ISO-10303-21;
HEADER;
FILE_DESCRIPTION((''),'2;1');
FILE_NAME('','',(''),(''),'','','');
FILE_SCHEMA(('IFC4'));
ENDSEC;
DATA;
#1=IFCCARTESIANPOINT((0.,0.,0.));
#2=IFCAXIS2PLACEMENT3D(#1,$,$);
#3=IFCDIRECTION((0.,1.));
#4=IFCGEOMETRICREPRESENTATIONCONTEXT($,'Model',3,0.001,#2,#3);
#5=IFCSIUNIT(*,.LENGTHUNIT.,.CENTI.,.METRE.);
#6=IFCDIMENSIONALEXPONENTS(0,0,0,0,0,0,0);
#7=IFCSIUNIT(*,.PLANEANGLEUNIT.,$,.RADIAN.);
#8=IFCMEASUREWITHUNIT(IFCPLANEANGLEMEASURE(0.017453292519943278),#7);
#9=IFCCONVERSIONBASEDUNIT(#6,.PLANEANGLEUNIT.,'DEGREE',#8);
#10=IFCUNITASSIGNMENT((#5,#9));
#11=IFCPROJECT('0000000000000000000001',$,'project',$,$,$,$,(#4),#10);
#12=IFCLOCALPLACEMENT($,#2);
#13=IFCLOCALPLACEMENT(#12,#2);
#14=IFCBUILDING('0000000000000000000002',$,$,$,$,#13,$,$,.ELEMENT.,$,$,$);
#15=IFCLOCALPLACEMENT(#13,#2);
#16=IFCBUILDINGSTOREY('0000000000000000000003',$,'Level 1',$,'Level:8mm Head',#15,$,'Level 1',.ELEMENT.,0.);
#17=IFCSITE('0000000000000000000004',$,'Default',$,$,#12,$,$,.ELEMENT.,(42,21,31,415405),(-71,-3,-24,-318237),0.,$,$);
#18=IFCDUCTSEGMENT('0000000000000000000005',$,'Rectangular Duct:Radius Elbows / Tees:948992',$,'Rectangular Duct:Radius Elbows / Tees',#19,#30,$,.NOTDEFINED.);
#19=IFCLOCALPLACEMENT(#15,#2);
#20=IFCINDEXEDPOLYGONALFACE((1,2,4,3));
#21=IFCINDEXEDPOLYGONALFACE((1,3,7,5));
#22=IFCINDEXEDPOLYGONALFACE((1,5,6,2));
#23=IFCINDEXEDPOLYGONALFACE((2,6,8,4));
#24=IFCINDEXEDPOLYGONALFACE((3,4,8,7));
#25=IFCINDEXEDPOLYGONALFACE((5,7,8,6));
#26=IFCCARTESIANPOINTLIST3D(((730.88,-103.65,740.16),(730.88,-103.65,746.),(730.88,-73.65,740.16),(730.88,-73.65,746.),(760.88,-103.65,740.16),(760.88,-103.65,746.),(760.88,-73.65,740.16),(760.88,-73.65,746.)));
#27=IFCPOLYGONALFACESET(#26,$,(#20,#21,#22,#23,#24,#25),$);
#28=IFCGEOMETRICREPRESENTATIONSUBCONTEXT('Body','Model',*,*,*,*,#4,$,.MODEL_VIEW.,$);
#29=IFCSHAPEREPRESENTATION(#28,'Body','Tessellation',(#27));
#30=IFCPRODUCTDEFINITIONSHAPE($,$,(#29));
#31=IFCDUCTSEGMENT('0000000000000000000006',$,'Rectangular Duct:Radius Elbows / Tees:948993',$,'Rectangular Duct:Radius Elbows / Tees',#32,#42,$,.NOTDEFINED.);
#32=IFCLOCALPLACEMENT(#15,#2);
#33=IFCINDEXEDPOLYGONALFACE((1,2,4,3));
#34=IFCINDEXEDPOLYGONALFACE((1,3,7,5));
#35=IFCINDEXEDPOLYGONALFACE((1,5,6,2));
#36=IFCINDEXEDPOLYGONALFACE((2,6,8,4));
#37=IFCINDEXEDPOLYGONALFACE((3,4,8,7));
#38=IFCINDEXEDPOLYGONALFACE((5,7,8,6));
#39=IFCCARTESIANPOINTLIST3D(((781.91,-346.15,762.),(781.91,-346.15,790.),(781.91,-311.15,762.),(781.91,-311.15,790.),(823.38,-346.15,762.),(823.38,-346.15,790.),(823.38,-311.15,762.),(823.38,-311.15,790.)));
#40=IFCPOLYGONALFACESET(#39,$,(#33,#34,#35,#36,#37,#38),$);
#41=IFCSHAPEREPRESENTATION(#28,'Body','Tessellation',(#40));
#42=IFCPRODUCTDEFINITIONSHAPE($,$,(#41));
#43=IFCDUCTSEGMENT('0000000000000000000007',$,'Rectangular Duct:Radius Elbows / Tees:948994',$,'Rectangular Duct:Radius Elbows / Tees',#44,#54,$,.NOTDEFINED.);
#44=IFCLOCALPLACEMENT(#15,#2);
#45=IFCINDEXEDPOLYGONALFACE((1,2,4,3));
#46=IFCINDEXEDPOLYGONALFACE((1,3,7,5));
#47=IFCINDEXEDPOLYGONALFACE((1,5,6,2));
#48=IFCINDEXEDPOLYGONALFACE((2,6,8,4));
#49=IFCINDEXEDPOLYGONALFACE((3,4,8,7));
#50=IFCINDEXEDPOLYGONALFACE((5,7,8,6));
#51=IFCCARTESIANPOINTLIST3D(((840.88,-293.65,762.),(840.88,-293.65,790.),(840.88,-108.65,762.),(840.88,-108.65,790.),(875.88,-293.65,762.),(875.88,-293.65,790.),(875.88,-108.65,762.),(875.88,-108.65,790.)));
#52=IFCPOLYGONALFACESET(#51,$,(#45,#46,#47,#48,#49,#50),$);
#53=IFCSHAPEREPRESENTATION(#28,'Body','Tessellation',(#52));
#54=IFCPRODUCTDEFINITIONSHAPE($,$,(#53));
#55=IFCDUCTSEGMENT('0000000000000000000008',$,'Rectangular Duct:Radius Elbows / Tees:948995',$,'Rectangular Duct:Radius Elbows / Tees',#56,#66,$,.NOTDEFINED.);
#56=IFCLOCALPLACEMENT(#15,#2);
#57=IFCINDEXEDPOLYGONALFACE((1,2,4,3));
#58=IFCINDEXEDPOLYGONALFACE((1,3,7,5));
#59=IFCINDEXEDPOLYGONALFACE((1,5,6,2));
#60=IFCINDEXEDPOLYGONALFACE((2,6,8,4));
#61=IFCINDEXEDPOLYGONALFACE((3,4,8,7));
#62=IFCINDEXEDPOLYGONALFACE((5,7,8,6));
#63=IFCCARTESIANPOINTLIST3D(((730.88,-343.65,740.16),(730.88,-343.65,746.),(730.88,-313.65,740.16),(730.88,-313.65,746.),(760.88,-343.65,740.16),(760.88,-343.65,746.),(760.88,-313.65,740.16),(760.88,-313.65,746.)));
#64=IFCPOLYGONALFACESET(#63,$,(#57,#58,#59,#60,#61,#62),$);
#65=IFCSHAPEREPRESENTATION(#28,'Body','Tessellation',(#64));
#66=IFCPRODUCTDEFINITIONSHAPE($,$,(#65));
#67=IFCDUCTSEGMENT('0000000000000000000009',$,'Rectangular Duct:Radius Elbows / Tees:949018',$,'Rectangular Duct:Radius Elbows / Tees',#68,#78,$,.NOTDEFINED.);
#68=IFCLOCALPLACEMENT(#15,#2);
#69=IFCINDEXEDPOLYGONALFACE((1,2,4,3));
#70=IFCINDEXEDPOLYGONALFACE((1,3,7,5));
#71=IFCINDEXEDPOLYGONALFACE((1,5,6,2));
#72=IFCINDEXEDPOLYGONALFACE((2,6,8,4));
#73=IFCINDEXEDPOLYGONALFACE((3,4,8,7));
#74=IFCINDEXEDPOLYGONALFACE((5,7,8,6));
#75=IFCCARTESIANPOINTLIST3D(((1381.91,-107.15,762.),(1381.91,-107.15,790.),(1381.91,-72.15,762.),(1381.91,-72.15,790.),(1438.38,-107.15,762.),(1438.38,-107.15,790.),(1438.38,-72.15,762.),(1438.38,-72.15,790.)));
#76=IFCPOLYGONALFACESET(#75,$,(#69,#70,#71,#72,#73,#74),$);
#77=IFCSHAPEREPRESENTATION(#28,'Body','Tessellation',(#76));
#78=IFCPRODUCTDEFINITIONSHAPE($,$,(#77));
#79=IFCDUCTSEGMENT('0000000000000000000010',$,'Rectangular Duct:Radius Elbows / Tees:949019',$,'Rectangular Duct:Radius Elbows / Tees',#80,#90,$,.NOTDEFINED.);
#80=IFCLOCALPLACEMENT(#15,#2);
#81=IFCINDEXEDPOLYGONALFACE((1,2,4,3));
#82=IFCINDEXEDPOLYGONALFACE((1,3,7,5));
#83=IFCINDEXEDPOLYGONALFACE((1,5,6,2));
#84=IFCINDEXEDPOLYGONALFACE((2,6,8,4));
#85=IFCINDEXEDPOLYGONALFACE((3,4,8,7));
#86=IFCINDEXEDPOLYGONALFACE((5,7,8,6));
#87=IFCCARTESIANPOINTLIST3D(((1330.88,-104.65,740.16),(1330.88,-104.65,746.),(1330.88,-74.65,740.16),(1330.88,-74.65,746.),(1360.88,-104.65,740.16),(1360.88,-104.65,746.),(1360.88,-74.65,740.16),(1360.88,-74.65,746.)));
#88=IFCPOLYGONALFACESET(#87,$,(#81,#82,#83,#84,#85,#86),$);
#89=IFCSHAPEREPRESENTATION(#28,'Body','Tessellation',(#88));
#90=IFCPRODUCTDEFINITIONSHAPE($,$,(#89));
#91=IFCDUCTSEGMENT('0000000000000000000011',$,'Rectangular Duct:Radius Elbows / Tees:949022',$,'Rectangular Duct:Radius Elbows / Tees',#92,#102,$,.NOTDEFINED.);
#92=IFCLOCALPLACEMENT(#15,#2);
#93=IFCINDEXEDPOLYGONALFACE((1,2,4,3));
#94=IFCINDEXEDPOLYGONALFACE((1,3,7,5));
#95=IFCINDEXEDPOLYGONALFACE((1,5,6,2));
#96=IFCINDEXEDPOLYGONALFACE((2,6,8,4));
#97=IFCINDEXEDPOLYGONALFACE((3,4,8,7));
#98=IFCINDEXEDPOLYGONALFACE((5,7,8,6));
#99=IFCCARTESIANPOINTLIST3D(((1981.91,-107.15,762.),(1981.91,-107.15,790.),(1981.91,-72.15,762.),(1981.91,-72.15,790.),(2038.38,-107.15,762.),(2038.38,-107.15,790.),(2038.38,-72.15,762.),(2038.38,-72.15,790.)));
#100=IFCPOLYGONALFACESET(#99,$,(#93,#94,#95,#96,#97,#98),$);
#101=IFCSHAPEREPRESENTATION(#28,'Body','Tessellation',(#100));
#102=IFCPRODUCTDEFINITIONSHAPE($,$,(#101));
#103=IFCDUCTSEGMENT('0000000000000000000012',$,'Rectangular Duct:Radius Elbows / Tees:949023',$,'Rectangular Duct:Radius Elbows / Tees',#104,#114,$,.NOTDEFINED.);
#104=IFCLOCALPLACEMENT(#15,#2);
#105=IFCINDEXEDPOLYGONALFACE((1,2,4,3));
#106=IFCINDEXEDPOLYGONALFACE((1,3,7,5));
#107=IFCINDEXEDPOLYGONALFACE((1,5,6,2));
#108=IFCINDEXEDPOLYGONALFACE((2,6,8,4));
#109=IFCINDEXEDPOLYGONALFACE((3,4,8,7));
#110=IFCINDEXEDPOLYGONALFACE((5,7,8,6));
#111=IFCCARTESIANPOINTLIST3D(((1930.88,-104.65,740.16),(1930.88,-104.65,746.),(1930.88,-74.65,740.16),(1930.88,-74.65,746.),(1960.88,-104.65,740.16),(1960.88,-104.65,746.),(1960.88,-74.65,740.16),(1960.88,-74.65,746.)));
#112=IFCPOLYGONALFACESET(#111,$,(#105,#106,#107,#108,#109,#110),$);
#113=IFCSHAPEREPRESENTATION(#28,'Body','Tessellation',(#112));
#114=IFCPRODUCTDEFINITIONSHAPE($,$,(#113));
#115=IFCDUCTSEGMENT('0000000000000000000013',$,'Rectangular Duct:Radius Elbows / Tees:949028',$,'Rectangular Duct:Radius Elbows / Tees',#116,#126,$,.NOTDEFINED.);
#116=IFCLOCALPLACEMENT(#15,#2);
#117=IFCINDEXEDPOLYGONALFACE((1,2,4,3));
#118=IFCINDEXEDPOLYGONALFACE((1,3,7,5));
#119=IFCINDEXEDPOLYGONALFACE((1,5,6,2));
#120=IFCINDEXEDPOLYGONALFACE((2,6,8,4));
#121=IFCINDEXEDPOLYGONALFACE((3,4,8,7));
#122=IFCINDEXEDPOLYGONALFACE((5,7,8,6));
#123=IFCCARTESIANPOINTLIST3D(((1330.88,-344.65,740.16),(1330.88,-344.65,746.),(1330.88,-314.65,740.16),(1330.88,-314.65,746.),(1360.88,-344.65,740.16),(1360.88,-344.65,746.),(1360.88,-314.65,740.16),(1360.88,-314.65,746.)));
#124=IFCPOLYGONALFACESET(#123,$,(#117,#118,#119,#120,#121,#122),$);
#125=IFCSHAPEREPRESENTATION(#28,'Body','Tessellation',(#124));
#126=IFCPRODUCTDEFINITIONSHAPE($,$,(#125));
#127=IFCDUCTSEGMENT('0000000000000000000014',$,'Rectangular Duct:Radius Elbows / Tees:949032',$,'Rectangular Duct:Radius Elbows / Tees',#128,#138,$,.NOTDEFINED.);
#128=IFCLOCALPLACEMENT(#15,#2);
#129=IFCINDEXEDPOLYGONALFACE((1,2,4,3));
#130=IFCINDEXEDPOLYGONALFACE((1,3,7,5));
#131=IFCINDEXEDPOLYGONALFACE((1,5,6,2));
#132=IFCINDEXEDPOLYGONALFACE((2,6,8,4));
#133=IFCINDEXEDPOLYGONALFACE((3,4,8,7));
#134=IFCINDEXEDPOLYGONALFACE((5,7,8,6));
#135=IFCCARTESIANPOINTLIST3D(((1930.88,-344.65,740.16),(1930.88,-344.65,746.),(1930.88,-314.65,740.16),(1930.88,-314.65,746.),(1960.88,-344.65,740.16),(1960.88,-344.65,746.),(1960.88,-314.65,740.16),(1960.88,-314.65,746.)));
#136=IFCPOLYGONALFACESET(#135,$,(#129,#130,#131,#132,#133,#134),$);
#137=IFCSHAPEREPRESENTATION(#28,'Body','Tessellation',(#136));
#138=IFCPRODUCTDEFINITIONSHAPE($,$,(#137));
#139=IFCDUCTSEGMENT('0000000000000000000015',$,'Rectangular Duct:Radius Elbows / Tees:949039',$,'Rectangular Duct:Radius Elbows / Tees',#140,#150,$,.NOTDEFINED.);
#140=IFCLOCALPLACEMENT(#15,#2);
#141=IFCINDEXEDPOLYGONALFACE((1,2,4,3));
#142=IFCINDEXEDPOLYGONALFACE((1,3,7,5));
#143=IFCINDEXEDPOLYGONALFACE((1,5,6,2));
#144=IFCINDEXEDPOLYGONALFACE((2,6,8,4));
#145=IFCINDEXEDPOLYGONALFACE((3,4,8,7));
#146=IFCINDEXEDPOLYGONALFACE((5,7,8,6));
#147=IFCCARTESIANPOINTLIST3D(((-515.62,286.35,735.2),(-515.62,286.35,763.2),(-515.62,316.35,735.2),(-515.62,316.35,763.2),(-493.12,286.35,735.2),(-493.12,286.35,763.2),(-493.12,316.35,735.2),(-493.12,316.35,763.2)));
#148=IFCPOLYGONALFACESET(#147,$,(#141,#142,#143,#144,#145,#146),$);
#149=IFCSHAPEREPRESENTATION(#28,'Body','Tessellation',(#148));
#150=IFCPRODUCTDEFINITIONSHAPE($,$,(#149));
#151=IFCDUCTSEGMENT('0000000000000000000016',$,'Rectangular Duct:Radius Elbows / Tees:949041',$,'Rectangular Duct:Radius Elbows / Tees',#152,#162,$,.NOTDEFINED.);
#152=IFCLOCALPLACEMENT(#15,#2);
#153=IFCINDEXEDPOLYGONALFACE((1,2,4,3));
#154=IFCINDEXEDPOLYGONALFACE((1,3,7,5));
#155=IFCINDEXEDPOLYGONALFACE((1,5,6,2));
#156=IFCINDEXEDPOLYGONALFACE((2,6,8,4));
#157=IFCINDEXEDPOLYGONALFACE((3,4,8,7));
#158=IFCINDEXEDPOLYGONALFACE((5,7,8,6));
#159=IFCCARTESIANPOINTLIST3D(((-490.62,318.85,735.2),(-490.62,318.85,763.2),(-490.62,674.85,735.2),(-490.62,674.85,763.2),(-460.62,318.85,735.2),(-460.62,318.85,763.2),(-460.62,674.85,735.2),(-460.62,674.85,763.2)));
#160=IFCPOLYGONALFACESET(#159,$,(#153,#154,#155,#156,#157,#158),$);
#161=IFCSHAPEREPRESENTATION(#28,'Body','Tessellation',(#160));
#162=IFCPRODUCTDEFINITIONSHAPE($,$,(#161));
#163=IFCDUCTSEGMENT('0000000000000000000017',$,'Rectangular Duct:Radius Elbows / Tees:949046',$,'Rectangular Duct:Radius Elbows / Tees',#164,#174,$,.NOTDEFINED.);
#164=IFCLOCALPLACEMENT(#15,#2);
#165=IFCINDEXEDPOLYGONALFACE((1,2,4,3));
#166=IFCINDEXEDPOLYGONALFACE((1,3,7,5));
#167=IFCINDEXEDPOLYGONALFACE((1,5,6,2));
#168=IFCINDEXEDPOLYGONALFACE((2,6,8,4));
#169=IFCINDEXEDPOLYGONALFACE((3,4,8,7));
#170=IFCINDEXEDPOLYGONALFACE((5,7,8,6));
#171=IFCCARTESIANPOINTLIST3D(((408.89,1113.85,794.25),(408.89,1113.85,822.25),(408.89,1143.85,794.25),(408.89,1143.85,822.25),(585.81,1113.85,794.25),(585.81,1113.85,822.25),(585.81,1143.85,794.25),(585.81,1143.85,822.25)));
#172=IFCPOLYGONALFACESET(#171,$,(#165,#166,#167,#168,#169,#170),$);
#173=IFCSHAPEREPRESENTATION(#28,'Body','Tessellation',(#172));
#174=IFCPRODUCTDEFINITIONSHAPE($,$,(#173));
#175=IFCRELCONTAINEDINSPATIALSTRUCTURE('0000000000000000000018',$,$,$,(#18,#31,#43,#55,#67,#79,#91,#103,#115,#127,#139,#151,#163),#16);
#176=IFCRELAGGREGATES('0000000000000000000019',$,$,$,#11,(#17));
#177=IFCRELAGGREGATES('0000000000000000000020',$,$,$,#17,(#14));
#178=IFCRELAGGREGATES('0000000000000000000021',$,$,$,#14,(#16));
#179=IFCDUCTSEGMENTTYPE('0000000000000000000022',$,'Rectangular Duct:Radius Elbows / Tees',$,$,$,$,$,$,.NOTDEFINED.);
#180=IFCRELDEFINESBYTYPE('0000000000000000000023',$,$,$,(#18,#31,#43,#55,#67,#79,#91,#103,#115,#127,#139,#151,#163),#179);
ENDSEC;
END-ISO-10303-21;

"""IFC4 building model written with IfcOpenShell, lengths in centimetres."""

from ifc_helpers import new_model, entity, si_unit, converted_unit, direction, frame, origin, place, context, subcontext, project, spatial, indexed_curve, outline, extrude, type_object, element, save


model = new_model("IFC4")

# Units and contexts
model_context = context("Model", 3, precision=0.001, world=origin(), true_north=direction((0.0, 1.0)))
body_context = subcontext(model_context, "Body", "Model", "MODEL_VIEW")
ifc_project = project(units=[si_unit("LENGTHUNIT", "METRE", prefix="CENTI"), converted_unit("PLANEANGLEUNIT", "DEGREE", entity("IfcPlaneAngleMeasure", 0.017453292519943278), si_unit("PLANEANGLEUNIT", "RADIAN"), dimensions=[0, 0, 0, 0, 0, 0, 0])], contexts=[model_context])

# Site, building, storey
site_placement = place(None, origin())
site = spatial("IfcSite", under=ifc_project, at=site_placement, Name="Default", CompositionType="ELEMENT", RefLatitude=(42, 21, 31, 415405), RefLongitude=(-71, -3, -24, -318237), RefElevation=0.0)
building_placement = place(site_placement, origin())
building = spatial("IfcBuilding", under=site, at=building_placement, CompositionType="ELEMENT")
storey_placement = place(building_placement, origin())
storey = spatial("IfcBuildingStorey", under=building, at=storey_placement, Name="Level 1", ObjectType="Level:8mm Head", LongName="Level 1", CompositionType="ELEMENT", Elevation=0.0)

# Duct segments
duct_segment_type = type_object("IfcDuctSegmentType", Name="Rectangular Duct:Radius Elbows / Tees", PredefinedType="NOTDEFINED")
duct_segment_1_placement = place(storey_placement, origin())
element("IfcDuctSegment", 1, at=duct_segment_1_placement, inside=storey, type_object=duct_segment_type, Name="Rectangular Duct:Radius Elbows / Tees:948992", ObjectType="Rectangular Duct:Radius Elbows / Tees", PredefinedType="NOTDEFINED", context=body_context, shape_type="SweptSolid", body=[
    extrude(outline(indexed_curve([(-15.0, -15.0), (15.0, -15.0), (15.0, 15.0), (-15.0, 15.0), (-15.0, -15.0)], self_intersect=False)), frame((745.88, -88.65, 740.16)), (0.0, 0.0, 1.0), 5.84),
])
duct_segment_2_placement = place(storey_placement, origin())
element("IfcDuctSegment", 2, at=duct_segment_2_placement, inside=storey, type_object=duct_segment_type, Name="Rectangular Duct:Radius Elbows / Tees:948993", ObjectType="Rectangular Duct:Radius Elbows / Tees", PredefinedType="NOTDEFINED", context=body_context, shape_type="SweptSolid", body=[
    extrude(outline(indexed_curve([(-20.73, -17.5), (20.73, -17.5), (20.73, 17.5), (-20.73, 17.5), (-20.73, -17.5)], self_intersect=False)), frame((802.64, -328.65, 762.0)), (0.0, 0.0, 1.0), 28.0),
])
duct_segment_3_placement = place(storey_placement, origin())
element("IfcDuctSegment", 3, at=duct_segment_3_placement, inside=storey, type_object=duct_segment_type, Name="Rectangular Duct:Radius Elbows / Tees:948994", ObjectType="Rectangular Duct:Radius Elbows / Tees", PredefinedType="NOTDEFINED", context=body_context, shape_type="SweptSolid", body=[
    extrude(outline(indexed_curve([(-92.5, -17.5), (92.5, -17.5), (92.5, 17.5), (-92.5, 17.5), (-92.5, -17.5)], self_intersect=False)), frame((858.38, -201.15, 762.0), z_axis=(0.0, 0.0, 1.0), x_axis=(0.0, -1.0, 0.0)), (0.0, 0.0, 1.0), 28.0),
])
duct_segment_4_placement = place(storey_placement, origin())
element("IfcDuctSegment", 4, at=duct_segment_4_placement, inside=storey, type_object=duct_segment_type, Name="Rectangular Duct:Radius Elbows / Tees:948995", ObjectType="Rectangular Duct:Radius Elbows / Tees", PredefinedType="NOTDEFINED", context=body_context, shape_type="SweptSolid", body=[
    extrude(outline(indexed_curve([(-15.0, -15.0), (15.0, -15.0), (15.0, 15.0), (-15.0, 15.0), (-15.0, -15.0)], self_intersect=False)), frame((745.88, -328.65, 740.16)), (0.0, 0.0, 1.0), 5.84),
])
duct_segment_5_placement = place(storey_placement, origin())
element("IfcDuctSegment", 5, at=duct_segment_5_placement, inside=storey, type_object=duct_segment_type, Name="Rectangular Duct:Radius Elbows / Tees:949018", ObjectType="Rectangular Duct:Radius Elbows / Tees", PredefinedType="NOTDEFINED", context=body_context, shape_type="SweptSolid", body=[
    extrude(outline(indexed_curve([(-28.23, -17.5), (28.23, -17.5), (28.23, 17.5), (-28.23, 17.5), (-28.23, -17.5)], self_intersect=False)), frame((1410.14, -89.65, 762.0)), (0.0, 0.0, 1.0), 28.0),
])
duct_segment_6_placement = place(storey_placement, origin())
element("IfcDuctSegment", 6, at=duct_segment_6_placement, inside=storey, type_object=duct_segment_type, Name="Rectangular Duct:Radius Elbows / Tees:949019", ObjectType="Rectangular Duct:Radius Elbows / Tees", PredefinedType="NOTDEFINED", context=body_context, shape_type="SweptSolid", body=[
    extrude(outline(indexed_curve([(-15.0, -15.0), (15.0, -15.0), (15.0, 15.0), (-15.0, 15.0), (-15.0, -15.0)], self_intersect=False)), frame((1345.88, -89.65, 740.16)), (0.0, 0.0, 1.0), 5.84),
])
duct_segment_7_placement = place(storey_placement, origin())
element("IfcDuctSegment", 7, at=duct_segment_7_placement, inside=storey, type_object=duct_segment_type, Name="Rectangular Duct:Radius Elbows / Tees:949022", ObjectType="Rectangular Duct:Radius Elbows / Tees", PredefinedType="NOTDEFINED", context=body_context, shape_type="SweptSolid", body=[
    extrude(outline(indexed_curve([(-28.23, -17.5), (28.23, -17.5), (28.23, 17.5), (-28.23, 17.5), (-28.23, -17.5)], self_intersect=False)), frame((2010.14, -89.65, 762.0)), (0.0, 0.0, 1.0), 28.0),
])
duct_segment_8_placement = place(storey_placement, origin())
element("IfcDuctSegment", 8, at=duct_segment_8_placement, inside=storey, type_object=duct_segment_type, Name="Rectangular Duct:Radius Elbows / Tees:949023", ObjectType="Rectangular Duct:Radius Elbows / Tees", PredefinedType="NOTDEFINED", context=body_context, shape_type="SweptSolid", body=[
    extrude(outline(indexed_curve([(-15.0, -15.0), (15.0, -15.0), (15.0, 15.0), (-15.0, 15.0), (-15.0, -15.0)], self_intersect=False)), frame((1945.88, -89.65, 740.16)), (0.0, 0.0, 1.0), 5.84),
])
duct_segment_9_placement = place(storey_placement, origin())
element("IfcDuctSegment", 9, at=duct_segment_9_placement, inside=storey, type_object=duct_segment_type, Name="Rectangular Duct:Radius Elbows / Tees:949028", ObjectType="Rectangular Duct:Radius Elbows / Tees", PredefinedType="NOTDEFINED", context=body_context, shape_type="SweptSolid", body=[
    extrude(outline(indexed_curve([(-15.0, -15.0), (15.0, -15.0), (15.0, 15.0), (-15.0, 15.0), (-15.0, -15.0)], self_intersect=False)), frame((1345.88, -329.65, 740.16)), (0.0, 0.0, 1.0), 5.84),
])
duct_segment_10_placement = place(storey_placement, origin())
element("IfcDuctSegment", 10, at=duct_segment_10_placement, inside=storey, type_object=duct_segment_type, Name="Rectangular Duct:Radius Elbows / Tees:949032", ObjectType="Rectangular Duct:Radius Elbows / Tees", PredefinedType="NOTDEFINED", context=body_context, shape_type="SweptSolid", body=[
    extrude(outline(indexed_curve([(-15.0, -15.0), (15.0, -15.0), (15.0, 15.0), (-15.0, 15.0), (-15.0, -15.0)], self_intersect=False)), frame((1945.88, -329.65, 740.16)), (0.0, 0.0, 1.0), 5.84),
])
duct_segment_11_placement = place(storey_placement, origin())
element("IfcDuctSegment", 11, at=duct_segment_11_placement, inside=storey, type_object=duct_segment_type, Name="Rectangular Duct:Radius Elbows / Tees:949039", ObjectType="Rectangular Duct:Radius Elbows / Tees", PredefinedType="NOTDEFINED", context=body_context, shape_type="SweptSolid", body=[
    extrude(outline(indexed_curve([(-11.25, -15.0), (11.25, -15.0), (11.25, 15.0), (-11.25, 15.0), (-11.25, -15.0)], self_intersect=False)), frame((-504.37, 301.35, 735.2), z_axis=(0.0, 0.0, 1.0), x_axis=(-1.0, 0.0, 0.0)), (0.0, 0.0, 1.0), 28.0),
])
duct_segment_12_placement = place(storey_placement, origin())
element("IfcDuctSegment", 12, at=duct_segment_12_placement, inside=storey, type_object=duct_segment_type, Name="Rectangular Duct:Radius Elbows / Tees:949041", ObjectType="Rectangular Duct:Radius Elbows / Tees", PredefinedType="NOTDEFINED", context=body_context, shape_type="SweptSolid", body=[
    extrude(outline(indexed_curve([(-178.0, -15.0), (178.0, -15.0), (178.0, 15.0), (-178.0, 15.0), (-178.0, -15.0)], self_intersect=False)), frame((-475.62, 496.85, 735.2), z_axis=(0.0, 0.0, 1.0), x_axis=(0.0, -1.0, 0.0)), (0.0, 0.0, 1.0), 28.0),
])
duct_segment_13_placement = place(storey_placement, origin())
element("IfcDuctSegment", 13, at=duct_segment_13_placement, inside=storey, type_object=duct_segment_type, Name="Rectangular Duct:Radius Elbows / Tees:949046", ObjectType="Rectangular Duct:Radius Elbows / Tees", PredefinedType="NOTDEFINED", context=body_context, shape_type="SweptSolid", body=[
    extrude(outline(indexed_curve([(-88.46, -15.0), (88.46, -15.0), (88.46, 15.0), (-88.46, 15.0), (-88.46, -15.0)], self_intersect=False)), frame((497.35, 1128.85, 794.25)), (0.0, 0.0, 1.0), 28.0),
])

save(model, "model.ifc")
